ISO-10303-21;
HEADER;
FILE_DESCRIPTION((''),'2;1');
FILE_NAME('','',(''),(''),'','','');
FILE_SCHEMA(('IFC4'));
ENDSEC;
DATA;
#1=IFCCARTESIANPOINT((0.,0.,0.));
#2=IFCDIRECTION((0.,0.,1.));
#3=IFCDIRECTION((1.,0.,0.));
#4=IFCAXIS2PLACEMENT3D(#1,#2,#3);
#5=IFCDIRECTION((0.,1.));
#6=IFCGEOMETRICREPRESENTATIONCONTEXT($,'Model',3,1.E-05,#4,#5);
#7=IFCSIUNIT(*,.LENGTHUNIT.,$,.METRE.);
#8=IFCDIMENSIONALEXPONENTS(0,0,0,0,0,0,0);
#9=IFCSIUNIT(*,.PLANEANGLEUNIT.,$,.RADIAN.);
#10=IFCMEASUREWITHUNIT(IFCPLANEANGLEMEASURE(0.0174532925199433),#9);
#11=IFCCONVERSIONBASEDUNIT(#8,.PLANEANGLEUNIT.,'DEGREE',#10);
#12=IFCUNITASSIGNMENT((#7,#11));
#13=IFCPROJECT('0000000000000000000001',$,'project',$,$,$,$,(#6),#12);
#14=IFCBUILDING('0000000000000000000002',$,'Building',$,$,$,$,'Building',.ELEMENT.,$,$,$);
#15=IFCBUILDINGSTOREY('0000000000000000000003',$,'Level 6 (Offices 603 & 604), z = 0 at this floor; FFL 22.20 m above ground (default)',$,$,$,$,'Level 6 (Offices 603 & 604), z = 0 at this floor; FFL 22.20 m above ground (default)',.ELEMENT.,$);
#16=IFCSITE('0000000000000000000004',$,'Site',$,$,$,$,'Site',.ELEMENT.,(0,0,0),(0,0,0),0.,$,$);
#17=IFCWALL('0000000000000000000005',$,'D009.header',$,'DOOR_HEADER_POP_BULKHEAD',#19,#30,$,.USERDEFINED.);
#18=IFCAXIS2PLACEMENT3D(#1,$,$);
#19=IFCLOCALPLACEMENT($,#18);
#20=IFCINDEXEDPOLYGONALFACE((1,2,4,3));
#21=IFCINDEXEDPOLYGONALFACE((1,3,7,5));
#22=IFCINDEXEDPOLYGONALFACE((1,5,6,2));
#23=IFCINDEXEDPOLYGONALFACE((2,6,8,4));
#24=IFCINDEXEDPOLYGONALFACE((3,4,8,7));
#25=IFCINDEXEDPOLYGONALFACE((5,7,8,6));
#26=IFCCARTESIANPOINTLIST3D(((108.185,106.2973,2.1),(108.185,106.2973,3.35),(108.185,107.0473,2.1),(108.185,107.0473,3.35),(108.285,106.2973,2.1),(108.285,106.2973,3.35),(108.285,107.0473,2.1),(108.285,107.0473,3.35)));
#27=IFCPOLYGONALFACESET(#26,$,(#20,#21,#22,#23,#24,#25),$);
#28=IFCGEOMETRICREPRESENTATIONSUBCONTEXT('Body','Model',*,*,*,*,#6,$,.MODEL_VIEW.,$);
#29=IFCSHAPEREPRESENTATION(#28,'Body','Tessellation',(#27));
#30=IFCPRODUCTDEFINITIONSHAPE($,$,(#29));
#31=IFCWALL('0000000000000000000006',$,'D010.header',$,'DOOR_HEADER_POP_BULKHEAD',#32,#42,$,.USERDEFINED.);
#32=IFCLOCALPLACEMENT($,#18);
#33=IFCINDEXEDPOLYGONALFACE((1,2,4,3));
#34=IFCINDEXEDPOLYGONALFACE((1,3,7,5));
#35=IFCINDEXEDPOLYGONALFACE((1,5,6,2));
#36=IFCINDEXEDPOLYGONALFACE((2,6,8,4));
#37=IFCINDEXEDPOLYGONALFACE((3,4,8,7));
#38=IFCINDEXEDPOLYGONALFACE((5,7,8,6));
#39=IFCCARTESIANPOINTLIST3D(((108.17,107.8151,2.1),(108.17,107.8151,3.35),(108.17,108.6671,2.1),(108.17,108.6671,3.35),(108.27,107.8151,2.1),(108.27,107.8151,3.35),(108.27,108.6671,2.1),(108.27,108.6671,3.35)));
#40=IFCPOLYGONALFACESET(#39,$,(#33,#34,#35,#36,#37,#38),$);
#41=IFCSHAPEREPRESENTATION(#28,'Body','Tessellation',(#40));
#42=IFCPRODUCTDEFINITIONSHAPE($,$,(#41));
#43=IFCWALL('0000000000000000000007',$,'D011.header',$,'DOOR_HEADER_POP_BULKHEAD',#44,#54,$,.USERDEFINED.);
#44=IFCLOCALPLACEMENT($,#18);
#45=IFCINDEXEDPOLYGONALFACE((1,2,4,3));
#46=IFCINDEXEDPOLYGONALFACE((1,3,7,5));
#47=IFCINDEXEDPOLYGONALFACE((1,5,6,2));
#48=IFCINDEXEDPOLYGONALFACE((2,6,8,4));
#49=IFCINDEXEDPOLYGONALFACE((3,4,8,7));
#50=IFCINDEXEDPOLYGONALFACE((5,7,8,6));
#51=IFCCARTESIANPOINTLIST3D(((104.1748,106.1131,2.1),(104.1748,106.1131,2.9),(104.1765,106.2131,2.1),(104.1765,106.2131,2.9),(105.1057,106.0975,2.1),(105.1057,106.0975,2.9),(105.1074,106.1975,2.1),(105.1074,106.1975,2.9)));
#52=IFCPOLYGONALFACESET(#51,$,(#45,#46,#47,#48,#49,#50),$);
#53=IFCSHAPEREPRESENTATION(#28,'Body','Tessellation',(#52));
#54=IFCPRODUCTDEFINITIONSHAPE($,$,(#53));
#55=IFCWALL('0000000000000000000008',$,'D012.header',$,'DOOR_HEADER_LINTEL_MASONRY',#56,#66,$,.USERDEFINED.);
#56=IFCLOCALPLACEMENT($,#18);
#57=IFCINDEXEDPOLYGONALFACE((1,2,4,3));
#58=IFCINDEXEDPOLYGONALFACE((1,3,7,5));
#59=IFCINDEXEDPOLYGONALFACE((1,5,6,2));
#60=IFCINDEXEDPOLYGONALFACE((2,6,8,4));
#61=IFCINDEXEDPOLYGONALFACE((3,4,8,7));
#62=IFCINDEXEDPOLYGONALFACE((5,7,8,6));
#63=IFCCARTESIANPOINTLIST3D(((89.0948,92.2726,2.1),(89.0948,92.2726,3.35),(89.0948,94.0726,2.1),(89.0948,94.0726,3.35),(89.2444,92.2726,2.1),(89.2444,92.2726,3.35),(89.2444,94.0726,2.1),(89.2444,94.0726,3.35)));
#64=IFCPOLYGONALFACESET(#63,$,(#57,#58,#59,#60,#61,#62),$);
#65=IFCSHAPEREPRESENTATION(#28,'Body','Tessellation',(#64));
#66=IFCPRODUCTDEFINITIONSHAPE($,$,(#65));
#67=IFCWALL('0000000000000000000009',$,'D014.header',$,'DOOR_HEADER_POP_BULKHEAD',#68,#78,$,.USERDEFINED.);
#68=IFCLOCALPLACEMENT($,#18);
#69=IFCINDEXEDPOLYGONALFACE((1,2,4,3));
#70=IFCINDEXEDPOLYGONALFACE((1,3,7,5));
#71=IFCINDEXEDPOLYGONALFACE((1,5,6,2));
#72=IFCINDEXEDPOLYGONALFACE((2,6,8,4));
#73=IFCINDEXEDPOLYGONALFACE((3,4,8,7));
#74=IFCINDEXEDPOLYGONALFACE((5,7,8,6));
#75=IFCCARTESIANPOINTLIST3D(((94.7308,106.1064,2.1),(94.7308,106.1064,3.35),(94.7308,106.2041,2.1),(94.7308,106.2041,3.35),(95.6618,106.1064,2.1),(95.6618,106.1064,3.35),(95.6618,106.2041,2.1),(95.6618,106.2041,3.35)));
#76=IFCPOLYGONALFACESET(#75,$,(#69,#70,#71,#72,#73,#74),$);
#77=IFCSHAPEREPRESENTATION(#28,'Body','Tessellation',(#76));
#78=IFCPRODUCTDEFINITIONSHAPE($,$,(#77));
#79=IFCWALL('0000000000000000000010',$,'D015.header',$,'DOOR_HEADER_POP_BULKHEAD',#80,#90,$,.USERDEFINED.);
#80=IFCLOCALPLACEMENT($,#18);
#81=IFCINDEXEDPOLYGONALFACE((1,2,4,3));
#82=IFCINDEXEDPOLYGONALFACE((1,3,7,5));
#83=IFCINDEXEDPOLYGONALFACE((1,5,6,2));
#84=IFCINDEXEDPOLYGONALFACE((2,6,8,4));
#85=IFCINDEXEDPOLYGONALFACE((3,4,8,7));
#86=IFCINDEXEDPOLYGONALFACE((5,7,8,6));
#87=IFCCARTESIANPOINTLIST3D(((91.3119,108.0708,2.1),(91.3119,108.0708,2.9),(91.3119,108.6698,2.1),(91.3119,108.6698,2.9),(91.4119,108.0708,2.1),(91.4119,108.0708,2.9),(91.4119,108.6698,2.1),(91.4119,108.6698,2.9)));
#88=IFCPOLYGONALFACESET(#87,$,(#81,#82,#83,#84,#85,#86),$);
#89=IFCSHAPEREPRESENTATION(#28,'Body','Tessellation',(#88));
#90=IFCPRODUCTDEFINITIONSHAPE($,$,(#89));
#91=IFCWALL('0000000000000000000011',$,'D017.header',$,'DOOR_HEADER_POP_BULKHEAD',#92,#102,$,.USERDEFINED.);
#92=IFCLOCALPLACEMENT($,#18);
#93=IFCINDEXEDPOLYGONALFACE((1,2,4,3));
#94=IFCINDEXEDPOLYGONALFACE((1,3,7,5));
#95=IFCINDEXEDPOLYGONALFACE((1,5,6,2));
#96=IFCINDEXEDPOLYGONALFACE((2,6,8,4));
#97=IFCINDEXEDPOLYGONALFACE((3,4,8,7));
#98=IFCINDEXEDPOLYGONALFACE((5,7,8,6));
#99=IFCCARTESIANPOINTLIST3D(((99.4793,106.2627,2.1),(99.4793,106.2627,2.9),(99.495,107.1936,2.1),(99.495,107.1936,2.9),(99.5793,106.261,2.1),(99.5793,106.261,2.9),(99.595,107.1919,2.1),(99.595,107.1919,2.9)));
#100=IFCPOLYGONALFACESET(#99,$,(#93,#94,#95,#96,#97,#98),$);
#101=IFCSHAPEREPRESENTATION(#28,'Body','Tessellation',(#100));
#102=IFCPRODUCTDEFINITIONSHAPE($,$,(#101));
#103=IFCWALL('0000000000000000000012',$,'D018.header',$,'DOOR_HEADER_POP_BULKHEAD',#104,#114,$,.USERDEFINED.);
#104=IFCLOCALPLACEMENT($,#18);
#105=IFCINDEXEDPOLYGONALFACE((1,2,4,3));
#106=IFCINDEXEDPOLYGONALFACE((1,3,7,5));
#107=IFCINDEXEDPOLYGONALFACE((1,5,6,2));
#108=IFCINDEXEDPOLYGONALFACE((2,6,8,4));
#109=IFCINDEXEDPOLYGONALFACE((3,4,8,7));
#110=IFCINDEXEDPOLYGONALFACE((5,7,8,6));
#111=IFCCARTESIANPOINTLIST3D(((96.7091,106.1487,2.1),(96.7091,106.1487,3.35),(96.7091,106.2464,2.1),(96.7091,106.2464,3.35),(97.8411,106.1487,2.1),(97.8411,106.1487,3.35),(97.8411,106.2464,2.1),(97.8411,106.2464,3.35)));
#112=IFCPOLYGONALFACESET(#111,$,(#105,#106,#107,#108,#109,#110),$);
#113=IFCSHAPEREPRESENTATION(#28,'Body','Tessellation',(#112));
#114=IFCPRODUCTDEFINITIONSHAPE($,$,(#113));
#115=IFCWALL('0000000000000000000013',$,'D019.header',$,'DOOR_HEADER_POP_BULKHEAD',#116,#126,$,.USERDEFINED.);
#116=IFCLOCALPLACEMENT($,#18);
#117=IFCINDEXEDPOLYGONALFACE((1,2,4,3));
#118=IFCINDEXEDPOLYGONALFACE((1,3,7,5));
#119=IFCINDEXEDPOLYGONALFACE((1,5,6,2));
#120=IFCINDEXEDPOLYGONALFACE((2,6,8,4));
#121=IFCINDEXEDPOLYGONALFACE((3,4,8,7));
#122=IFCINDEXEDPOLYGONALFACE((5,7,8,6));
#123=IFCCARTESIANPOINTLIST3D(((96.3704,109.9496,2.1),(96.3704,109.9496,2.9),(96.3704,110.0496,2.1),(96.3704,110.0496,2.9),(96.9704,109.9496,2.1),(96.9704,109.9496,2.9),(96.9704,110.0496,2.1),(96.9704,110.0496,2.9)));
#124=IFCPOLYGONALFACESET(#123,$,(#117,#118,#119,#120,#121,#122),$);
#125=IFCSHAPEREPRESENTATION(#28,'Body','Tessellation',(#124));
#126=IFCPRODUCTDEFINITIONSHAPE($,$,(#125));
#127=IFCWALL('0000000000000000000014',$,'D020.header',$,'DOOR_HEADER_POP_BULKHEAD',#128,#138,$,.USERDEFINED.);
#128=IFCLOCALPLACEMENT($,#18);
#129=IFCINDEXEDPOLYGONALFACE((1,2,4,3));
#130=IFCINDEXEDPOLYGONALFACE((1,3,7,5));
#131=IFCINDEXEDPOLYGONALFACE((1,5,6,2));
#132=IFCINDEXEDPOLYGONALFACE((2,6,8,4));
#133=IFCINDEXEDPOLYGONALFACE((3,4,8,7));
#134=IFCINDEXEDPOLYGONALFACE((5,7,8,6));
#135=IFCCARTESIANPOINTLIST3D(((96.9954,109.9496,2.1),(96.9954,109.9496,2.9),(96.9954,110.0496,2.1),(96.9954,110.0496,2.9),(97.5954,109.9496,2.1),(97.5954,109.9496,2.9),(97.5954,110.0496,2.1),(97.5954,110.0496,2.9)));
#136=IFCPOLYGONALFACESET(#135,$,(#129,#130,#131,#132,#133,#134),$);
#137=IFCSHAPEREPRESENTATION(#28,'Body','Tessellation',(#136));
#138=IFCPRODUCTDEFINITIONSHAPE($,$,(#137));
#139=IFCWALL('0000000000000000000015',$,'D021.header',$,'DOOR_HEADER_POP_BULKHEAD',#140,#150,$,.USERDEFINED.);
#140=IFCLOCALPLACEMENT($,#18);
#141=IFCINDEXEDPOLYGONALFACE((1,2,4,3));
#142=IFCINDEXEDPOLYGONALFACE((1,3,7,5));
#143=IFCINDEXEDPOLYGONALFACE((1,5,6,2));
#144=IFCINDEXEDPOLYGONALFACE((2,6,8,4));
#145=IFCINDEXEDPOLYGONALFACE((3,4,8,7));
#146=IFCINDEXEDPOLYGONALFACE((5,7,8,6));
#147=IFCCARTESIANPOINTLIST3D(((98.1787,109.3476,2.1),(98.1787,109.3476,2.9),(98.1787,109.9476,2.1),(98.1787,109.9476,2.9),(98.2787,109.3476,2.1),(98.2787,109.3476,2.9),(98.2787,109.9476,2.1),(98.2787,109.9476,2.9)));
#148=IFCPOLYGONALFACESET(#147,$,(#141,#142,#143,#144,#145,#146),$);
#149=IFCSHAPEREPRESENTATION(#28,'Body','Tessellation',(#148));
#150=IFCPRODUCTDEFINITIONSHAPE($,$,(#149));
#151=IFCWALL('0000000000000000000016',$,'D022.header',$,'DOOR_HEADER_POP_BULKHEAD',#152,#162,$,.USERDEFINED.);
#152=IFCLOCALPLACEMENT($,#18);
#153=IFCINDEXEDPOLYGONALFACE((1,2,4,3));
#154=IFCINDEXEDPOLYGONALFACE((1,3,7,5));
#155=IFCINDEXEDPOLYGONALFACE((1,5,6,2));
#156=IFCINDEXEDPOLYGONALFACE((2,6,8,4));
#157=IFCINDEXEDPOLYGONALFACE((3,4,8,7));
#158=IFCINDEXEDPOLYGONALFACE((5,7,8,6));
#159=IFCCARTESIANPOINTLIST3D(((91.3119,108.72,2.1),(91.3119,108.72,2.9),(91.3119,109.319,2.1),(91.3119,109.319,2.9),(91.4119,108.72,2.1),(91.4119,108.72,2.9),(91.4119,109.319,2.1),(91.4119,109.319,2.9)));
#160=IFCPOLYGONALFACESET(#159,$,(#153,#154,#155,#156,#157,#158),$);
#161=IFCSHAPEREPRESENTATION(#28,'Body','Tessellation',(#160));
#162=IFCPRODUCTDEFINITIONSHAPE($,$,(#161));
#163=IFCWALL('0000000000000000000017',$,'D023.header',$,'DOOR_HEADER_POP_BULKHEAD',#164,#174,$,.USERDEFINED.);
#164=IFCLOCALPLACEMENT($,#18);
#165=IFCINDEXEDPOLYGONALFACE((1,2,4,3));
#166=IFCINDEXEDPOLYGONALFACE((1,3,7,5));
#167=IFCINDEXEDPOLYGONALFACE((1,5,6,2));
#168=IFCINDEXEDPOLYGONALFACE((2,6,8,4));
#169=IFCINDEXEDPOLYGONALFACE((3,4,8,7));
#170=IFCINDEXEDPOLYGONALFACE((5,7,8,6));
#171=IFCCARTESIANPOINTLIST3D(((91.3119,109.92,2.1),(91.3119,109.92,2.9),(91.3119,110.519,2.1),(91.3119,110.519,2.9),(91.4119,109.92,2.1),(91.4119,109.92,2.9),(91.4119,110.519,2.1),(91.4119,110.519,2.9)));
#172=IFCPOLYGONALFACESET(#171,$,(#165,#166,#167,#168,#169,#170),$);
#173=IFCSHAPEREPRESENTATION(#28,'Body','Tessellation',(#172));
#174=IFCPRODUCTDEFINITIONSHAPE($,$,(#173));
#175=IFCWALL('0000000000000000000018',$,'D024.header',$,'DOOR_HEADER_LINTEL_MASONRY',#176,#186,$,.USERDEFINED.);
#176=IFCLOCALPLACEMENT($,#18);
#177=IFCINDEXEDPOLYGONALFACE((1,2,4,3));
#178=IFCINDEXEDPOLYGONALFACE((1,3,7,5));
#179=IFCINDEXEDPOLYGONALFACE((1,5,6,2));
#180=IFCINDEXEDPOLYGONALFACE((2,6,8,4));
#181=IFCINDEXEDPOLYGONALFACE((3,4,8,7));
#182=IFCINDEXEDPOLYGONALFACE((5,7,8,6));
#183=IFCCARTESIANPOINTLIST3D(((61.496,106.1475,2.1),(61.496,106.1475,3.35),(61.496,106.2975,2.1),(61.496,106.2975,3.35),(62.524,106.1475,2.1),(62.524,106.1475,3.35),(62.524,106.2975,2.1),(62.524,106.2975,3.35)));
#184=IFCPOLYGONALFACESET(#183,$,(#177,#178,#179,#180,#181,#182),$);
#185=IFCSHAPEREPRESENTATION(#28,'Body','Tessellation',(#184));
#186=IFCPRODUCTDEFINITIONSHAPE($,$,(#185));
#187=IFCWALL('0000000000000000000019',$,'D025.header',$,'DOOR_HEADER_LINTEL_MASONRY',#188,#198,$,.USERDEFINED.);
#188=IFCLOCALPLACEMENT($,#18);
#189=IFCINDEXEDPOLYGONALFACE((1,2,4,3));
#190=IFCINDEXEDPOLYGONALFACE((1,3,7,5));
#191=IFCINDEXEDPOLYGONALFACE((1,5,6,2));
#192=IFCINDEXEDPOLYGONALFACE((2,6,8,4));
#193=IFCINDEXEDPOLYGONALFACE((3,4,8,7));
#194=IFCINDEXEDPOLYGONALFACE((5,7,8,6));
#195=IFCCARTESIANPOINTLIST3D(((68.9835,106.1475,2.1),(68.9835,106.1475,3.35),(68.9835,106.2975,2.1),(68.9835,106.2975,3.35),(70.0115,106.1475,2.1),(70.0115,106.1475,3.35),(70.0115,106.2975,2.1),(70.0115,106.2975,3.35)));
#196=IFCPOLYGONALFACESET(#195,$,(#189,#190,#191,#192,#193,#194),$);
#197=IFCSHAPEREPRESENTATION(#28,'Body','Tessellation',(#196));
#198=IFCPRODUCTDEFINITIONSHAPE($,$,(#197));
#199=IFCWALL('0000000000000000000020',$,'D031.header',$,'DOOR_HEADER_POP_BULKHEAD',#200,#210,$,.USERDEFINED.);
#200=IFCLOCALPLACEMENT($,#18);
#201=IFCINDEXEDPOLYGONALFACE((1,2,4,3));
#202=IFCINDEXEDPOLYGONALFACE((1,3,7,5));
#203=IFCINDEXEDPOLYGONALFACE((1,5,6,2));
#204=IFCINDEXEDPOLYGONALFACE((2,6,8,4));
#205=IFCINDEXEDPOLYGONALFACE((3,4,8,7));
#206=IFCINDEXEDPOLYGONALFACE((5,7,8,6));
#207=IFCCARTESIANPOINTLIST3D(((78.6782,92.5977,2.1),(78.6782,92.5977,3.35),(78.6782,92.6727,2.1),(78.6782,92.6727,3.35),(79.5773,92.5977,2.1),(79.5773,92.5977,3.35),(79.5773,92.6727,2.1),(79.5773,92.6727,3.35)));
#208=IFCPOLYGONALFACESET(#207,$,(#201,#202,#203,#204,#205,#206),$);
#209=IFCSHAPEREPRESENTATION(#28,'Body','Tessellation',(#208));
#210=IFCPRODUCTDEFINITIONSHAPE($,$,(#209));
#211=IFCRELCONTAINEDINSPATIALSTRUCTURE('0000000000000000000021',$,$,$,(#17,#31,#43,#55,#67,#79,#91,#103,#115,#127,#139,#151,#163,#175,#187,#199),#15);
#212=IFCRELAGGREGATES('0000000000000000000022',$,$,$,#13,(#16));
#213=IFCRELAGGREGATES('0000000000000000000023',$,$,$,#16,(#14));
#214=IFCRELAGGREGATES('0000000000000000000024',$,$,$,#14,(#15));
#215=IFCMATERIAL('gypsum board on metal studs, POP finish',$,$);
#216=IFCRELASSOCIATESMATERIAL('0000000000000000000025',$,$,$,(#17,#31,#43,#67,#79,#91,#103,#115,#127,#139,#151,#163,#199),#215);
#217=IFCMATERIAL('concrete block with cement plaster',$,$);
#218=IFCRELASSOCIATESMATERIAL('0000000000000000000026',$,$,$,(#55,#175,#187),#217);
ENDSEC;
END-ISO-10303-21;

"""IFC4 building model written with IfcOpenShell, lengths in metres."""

from ifc_helpers import new_model, entity, si_unit, converted_unit, direction, frame, frame_2d, origin_with_axes, origin_2d_with_axis, place, context, subcontext, project, spatial, rectangle, extrude, material, element, save


model = new_model("IFC4")

# Units and contexts
model_context = context("Model", 3, precision=1e-05, world=origin_with_axes(), true_north=direction((0.0, 1.0)))
body_context = subcontext(model_context, "Body", "Model", "MODEL_VIEW")
ifc_project = project(units=[si_unit("LENGTHUNIT", "METRE"), converted_unit("PLANEANGLEUNIT", "DEGREE", entity("IfcPlaneAngleMeasure", 0.0174532925199433), si_unit("PLANEANGLEUNIT", "RADIAN"), dimensions=[0, 0, 0, 0, 0, 0, 0])], contexts=[model_context])

# Site, building, storey
site = spatial("IfcSite", under=ifc_project, Name="Site", LongName="Site", CompositionType="ELEMENT", RefLatitude=(0, 0, 0), RefLongitude=(0, 0, 0), RefElevation=0.0)
building = spatial("IfcBuilding", under=site, Name="Building", LongName="Building", CompositionType="ELEMENT")
storey = spatial("IfcBuildingStorey", under=building, Name="Level 6 (Offices 603 & 604), z = 0 at this floor; FFL 22.20 m above ground (default)", LongName="Level 6 (Offices 603 & 604), z = 0 at this floor; FFL 22.20 m above ground (default)", CompositionType="ELEMENT")

# Shared definitions
placement = place(None, origin_with_axes())

# Walls
ifc_material_1 = material(Name="concrete block with cement plaster")
ifc_material_2 = material(Name="gypsum board on metal studs, POP finish")
element("IfcWall", 1, at=placement, inside=storey, material=ifc_material_2, Name="D009.header", ObjectType="DOOR_HEADER_POP_BULKHEAD", PredefinedType="USERDEFINED", context=body_context, shape_type="SweptSolid", body=[
    extrude(rectangle(XDim=0.75, YDim=0.1, at=frame_2d((0.0, 0.0), x_axis=(0.0, 1.0))), frame((108.235, 106.6723, 2.1), z_axis=(0.0, 0.0, 1.0), x_axis=(1.0, 0.0, 0.0)), (0.0, 0.0, 1.0), 1.25),
])
element("IfcWall", 2, at=placement, inside=storey, material=ifc_material_2, Name="D010.header", ObjectType="DOOR_HEADER_POP_BULKHEAD", PredefinedType="USERDEFINED", context=body_context, shape_type="SweptSolid", body=[
    extrude(rectangle(XDim=0.852, YDim=0.1, at=frame_2d((0.0, 0.0), x_axis=(0.0, 1.0))), frame((108.22, 108.2411, 2.1), z_axis=(0.0, 0.0, 1.0), x_axis=(1.0, 0.0, 0.0)), (0.0, 0.0, 1.0), 1.25),
])
element("IfcWall", 3, at=placement, inside=storey, material=ifc_material_2, Name="D011.header", ObjectType="DOOR_HEADER_POP_BULKHEAD", PredefinedType="USERDEFINED", context=body_context, shape_type="SweptSolid", body=[
    extrude(rectangle(XDim=0.931, YDim=0.1, at=frame_2d((0.0, 0.0), x_axis=(0.999859, -0.016765))), frame((104.6411, 106.1553, 2.1), z_axis=(0.0, 0.0, 1.0), x_axis=(1.0, 0.0, 0.0)), (0.0, 0.0, 1.0), 0.8),
])
element("IfcWall", 4, at=placement, inside=storey, material=ifc_material_1, Name="D012.header", ObjectType="DOOR_HEADER_LINTEL_MASONRY", PredefinedType="USERDEFINED", context=body_context, shape_type="SweptSolid", body=[
    extrude(rectangle(XDim=1.8, YDim=0.1496, at=frame_2d((0.0, 0.0), x_axis=(0.0, 1.0))), frame((89.1696, 93.1726, 2.1), z_axis=(0.0, 0.0, 1.0), x_axis=(1.0, 0.0, 0.0)), (0.0, 0.0, 1.0), 1.25),
])
element("IfcWall", 5, at=placement, inside=storey, material=ifc_material_2, Name="D014.header", ObjectType="DOOR_HEADER_POP_BULKHEAD", PredefinedType="USERDEFINED", context=body_context, shape_type="SweptSolid", body=[
    extrude(rectangle(XDim=0.931, YDim=0.0977, at=frame_2d((0.0, 0.0), x_axis=(1.0, 0.0))), frame((95.1963, 106.1553, 2.1), z_axis=(0.0, 0.0, 1.0), x_axis=(1.0, 0.0, 0.0)), (0.0, 0.0, 1.0), 1.25),
])
element("IfcWall", 6, at=placement, inside=storey, material=ifc_material_2, Name="D015.header", ObjectType="DOOR_HEADER_POP_BULKHEAD", PredefinedType="USERDEFINED", context=body_context, shape_type="SweptSolid", body=[
    extrude(rectangle(XDim=0.599, YDim=0.1, at=frame_2d((0.0, 0.0), x_axis=(0.0, 1.0))), frame((91.3619, 108.3704, 2.1), z_axis=(0.0, 0.0, 1.0), x_axis=(1.0, 0.0, 0.0)), (0.0, 0.0, 1.0), 0.8),
])
element("IfcWall", 7, at=placement, inside=storey, material=ifc_material_2, Name="D017.header", ObjectType="DOOR_HEADER_POP_BULKHEAD", PredefinedType="USERDEFINED", context=body_context, shape_type="SweptSolid", body=[
    extrude(rectangle(XDim=0.931, YDim=0.1, at=frame_2d((0.0, 0.0), x_axis=(0.016872, 0.999858))), frame((99.5371, 106.7273, 2.1), z_axis=(0.0, 0.0, 1.0), x_axis=(1.0, 0.0, 0.0)), (0.0, 0.0, 1.0), 0.8),
])
element("IfcWall", 8, at=placement, inside=storey, material=ifc_material_2, Name="D018.header", ObjectType="DOOR_HEADER_POP_BULKHEAD", PredefinedType="USERDEFINED", context=body_context, shape_type="SweptSolid", body=[
    extrude(rectangle(XDim=1.132, YDim=0.0977, at=frame_2d((0.0, 0.0), x_axis=(1.0, 0.0))), frame((97.2751, 106.1975, 2.1), z_axis=(0.0, 0.0, 1.0), x_axis=(1.0, 0.0, 0.0)), (0.0, 0.0, 1.0), 1.25),
])
element("IfcWall", 9, at=placement, inside=storey, material=ifc_material_2, Name="D019.header", ObjectType="DOOR_HEADER_POP_BULKHEAD", PredefinedType="USERDEFINED", context=body_context, shape_type="SweptSolid", body=[
    extrude(rectangle(XDim=0.6, YDim=0.1, at=frame_2d((0.0, 0.0), x_axis=(1.0, 0.0))), frame((96.6704, 109.9996, 2.1), z_axis=(0.0, 0.0, 1.0), x_axis=(1.0, 0.0, 0.0)), (0.0, 0.0, 1.0), 0.8),
])
element("IfcWall", 10, at=placement, inside=storey, material=ifc_material_2, Name="D020.header", ObjectType="DOOR_HEADER_POP_BULKHEAD", PredefinedType="USERDEFINED", context=body_context, shape_type="SweptSolid", body=[
    extrude(rectangle(XDim=0.6, YDim=0.1, at=origin_2d_with_axis()), frame((97.2954, 109.9996, 2.1), z_axis=(0.0, 0.0, 1.0), x_axis=(1.0, 0.0, 0.0)), (0.0, 0.0, 1.0), 0.8),
])
element("IfcWall", 11, at=placement, inside=storey, material=ifc_material_2, Name="D021.header", ObjectType="DOOR_HEADER_POP_BULKHEAD", PredefinedType="USERDEFINED", context=body_context, shape_type="SweptSolid", body=[
    extrude(rectangle(XDim=0.6, YDim=0.1, at=frame_2d((0.0, 0.0), x_axis=(0.0, 1.0))), frame((98.2287, 109.6476, 2.1), z_axis=(0.0, 0.0, 1.0), x_axis=(1.0, 0.0, 0.0)), (0.0, 0.0, 1.0), 0.8),
])
element("IfcWall", 12, at=placement, inside=storey, material=ifc_material_2, Name="D022.header", ObjectType="DOOR_HEADER_POP_BULKHEAD", PredefinedType="USERDEFINED", context=body_context, shape_type="SweptSolid", body=[
    extrude(rectangle(XDim=0.599, YDim=0.1, at=frame_2d((0.0, 0.0), x_axis=(0.0, 1.0))), frame((91.3619, 109.0195, 2.1), z_axis=(0.0, 0.0, 1.0), x_axis=(1.0, 0.0, 0.0)), (0.0, 0.0, 1.0), 0.8),
])
element("IfcWall", 13, at=placement, inside=storey, material=ifc_material_2, Name="D023.header", ObjectType="DOOR_HEADER_POP_BULKHEAD", PredefinedType="USERDEFINED", context=body_context, shape_type="SweptSolid", body=[
    extrude(rectangle(XDim=0.599, YDim=0.1, at=frame_2d((0.0, 0.0), x_axis=(0.0, 1.0))), frame((91.3619, 110.2195, 2.1), z_axis=(0.0, 0.0, 1.0), x_axis=(1.0, 0.0, 0.0)), (0.0, 0.0, 1.0), 0.8),
])
element("IfcWall", 14, at=placement, inside=storey, material=ifc_material_1, Name="D024.header", ObjectType="DOOR_HEADER_LINTEL_MASONRY", PredefinedType="USERDEFINED", context=body_context, shape_type="SweptSolid", body=[
    extrude(rectangle(XDim=1.028, YDim=0.15, at=frame_2d((0.0, 0.0), x_axis=(1.0, 0.0))), frame((62.01, 106.2225, 2.1), z_axis=(0.0, 0.0, 1.0), x_axis=(1.0, 0.0, 0.0)), (0.0, 0.0, 1.0), 1.25),
])
element("IfcWall", 15, at=placement, inside=storey, material=ifc_material_1, Name="D025.header", ObjectType="DOOR_HEADER_LINTEL_MASONRY", PredefinedType="USERDEFINED", context=body_context, shape_type="SweptSolid", body=[
    extrude(rectangle(XDim=1.028, YDim=0.15, at=origin_2d_with_axis()), frame((69.4975, 106.2225, 2.1), z_axis=(0.0, 0.0, 1.0), x_axis=(1.0, 0.0, 0.0)), (0.0, 0.0, 1.0), 1.25),
])
element("IfcWall", 16, at=placement, inside=storey, material=ifc_material_2, Name="D031.header", ObjectType="DOOR_HEADER_POP_BULKHEAD", PredefinedType="USERDEFINED", context=body_context, shape_type="SweptSolid", body=[
    extrude(rectangle(XDim=0.899, YDim=0.075, at=frame_2d((0.0, 0.0), x_axis=(1.0, 0.0))), frame((79.1278, 92.6352, 2.1), z_axis=(0.0, 0.0, 1.0), x_axis=(1.0, 0.0, 0.0)), (0.0, 0.0, 1.0), 1.25),
])

save(model, "model.ifc")
